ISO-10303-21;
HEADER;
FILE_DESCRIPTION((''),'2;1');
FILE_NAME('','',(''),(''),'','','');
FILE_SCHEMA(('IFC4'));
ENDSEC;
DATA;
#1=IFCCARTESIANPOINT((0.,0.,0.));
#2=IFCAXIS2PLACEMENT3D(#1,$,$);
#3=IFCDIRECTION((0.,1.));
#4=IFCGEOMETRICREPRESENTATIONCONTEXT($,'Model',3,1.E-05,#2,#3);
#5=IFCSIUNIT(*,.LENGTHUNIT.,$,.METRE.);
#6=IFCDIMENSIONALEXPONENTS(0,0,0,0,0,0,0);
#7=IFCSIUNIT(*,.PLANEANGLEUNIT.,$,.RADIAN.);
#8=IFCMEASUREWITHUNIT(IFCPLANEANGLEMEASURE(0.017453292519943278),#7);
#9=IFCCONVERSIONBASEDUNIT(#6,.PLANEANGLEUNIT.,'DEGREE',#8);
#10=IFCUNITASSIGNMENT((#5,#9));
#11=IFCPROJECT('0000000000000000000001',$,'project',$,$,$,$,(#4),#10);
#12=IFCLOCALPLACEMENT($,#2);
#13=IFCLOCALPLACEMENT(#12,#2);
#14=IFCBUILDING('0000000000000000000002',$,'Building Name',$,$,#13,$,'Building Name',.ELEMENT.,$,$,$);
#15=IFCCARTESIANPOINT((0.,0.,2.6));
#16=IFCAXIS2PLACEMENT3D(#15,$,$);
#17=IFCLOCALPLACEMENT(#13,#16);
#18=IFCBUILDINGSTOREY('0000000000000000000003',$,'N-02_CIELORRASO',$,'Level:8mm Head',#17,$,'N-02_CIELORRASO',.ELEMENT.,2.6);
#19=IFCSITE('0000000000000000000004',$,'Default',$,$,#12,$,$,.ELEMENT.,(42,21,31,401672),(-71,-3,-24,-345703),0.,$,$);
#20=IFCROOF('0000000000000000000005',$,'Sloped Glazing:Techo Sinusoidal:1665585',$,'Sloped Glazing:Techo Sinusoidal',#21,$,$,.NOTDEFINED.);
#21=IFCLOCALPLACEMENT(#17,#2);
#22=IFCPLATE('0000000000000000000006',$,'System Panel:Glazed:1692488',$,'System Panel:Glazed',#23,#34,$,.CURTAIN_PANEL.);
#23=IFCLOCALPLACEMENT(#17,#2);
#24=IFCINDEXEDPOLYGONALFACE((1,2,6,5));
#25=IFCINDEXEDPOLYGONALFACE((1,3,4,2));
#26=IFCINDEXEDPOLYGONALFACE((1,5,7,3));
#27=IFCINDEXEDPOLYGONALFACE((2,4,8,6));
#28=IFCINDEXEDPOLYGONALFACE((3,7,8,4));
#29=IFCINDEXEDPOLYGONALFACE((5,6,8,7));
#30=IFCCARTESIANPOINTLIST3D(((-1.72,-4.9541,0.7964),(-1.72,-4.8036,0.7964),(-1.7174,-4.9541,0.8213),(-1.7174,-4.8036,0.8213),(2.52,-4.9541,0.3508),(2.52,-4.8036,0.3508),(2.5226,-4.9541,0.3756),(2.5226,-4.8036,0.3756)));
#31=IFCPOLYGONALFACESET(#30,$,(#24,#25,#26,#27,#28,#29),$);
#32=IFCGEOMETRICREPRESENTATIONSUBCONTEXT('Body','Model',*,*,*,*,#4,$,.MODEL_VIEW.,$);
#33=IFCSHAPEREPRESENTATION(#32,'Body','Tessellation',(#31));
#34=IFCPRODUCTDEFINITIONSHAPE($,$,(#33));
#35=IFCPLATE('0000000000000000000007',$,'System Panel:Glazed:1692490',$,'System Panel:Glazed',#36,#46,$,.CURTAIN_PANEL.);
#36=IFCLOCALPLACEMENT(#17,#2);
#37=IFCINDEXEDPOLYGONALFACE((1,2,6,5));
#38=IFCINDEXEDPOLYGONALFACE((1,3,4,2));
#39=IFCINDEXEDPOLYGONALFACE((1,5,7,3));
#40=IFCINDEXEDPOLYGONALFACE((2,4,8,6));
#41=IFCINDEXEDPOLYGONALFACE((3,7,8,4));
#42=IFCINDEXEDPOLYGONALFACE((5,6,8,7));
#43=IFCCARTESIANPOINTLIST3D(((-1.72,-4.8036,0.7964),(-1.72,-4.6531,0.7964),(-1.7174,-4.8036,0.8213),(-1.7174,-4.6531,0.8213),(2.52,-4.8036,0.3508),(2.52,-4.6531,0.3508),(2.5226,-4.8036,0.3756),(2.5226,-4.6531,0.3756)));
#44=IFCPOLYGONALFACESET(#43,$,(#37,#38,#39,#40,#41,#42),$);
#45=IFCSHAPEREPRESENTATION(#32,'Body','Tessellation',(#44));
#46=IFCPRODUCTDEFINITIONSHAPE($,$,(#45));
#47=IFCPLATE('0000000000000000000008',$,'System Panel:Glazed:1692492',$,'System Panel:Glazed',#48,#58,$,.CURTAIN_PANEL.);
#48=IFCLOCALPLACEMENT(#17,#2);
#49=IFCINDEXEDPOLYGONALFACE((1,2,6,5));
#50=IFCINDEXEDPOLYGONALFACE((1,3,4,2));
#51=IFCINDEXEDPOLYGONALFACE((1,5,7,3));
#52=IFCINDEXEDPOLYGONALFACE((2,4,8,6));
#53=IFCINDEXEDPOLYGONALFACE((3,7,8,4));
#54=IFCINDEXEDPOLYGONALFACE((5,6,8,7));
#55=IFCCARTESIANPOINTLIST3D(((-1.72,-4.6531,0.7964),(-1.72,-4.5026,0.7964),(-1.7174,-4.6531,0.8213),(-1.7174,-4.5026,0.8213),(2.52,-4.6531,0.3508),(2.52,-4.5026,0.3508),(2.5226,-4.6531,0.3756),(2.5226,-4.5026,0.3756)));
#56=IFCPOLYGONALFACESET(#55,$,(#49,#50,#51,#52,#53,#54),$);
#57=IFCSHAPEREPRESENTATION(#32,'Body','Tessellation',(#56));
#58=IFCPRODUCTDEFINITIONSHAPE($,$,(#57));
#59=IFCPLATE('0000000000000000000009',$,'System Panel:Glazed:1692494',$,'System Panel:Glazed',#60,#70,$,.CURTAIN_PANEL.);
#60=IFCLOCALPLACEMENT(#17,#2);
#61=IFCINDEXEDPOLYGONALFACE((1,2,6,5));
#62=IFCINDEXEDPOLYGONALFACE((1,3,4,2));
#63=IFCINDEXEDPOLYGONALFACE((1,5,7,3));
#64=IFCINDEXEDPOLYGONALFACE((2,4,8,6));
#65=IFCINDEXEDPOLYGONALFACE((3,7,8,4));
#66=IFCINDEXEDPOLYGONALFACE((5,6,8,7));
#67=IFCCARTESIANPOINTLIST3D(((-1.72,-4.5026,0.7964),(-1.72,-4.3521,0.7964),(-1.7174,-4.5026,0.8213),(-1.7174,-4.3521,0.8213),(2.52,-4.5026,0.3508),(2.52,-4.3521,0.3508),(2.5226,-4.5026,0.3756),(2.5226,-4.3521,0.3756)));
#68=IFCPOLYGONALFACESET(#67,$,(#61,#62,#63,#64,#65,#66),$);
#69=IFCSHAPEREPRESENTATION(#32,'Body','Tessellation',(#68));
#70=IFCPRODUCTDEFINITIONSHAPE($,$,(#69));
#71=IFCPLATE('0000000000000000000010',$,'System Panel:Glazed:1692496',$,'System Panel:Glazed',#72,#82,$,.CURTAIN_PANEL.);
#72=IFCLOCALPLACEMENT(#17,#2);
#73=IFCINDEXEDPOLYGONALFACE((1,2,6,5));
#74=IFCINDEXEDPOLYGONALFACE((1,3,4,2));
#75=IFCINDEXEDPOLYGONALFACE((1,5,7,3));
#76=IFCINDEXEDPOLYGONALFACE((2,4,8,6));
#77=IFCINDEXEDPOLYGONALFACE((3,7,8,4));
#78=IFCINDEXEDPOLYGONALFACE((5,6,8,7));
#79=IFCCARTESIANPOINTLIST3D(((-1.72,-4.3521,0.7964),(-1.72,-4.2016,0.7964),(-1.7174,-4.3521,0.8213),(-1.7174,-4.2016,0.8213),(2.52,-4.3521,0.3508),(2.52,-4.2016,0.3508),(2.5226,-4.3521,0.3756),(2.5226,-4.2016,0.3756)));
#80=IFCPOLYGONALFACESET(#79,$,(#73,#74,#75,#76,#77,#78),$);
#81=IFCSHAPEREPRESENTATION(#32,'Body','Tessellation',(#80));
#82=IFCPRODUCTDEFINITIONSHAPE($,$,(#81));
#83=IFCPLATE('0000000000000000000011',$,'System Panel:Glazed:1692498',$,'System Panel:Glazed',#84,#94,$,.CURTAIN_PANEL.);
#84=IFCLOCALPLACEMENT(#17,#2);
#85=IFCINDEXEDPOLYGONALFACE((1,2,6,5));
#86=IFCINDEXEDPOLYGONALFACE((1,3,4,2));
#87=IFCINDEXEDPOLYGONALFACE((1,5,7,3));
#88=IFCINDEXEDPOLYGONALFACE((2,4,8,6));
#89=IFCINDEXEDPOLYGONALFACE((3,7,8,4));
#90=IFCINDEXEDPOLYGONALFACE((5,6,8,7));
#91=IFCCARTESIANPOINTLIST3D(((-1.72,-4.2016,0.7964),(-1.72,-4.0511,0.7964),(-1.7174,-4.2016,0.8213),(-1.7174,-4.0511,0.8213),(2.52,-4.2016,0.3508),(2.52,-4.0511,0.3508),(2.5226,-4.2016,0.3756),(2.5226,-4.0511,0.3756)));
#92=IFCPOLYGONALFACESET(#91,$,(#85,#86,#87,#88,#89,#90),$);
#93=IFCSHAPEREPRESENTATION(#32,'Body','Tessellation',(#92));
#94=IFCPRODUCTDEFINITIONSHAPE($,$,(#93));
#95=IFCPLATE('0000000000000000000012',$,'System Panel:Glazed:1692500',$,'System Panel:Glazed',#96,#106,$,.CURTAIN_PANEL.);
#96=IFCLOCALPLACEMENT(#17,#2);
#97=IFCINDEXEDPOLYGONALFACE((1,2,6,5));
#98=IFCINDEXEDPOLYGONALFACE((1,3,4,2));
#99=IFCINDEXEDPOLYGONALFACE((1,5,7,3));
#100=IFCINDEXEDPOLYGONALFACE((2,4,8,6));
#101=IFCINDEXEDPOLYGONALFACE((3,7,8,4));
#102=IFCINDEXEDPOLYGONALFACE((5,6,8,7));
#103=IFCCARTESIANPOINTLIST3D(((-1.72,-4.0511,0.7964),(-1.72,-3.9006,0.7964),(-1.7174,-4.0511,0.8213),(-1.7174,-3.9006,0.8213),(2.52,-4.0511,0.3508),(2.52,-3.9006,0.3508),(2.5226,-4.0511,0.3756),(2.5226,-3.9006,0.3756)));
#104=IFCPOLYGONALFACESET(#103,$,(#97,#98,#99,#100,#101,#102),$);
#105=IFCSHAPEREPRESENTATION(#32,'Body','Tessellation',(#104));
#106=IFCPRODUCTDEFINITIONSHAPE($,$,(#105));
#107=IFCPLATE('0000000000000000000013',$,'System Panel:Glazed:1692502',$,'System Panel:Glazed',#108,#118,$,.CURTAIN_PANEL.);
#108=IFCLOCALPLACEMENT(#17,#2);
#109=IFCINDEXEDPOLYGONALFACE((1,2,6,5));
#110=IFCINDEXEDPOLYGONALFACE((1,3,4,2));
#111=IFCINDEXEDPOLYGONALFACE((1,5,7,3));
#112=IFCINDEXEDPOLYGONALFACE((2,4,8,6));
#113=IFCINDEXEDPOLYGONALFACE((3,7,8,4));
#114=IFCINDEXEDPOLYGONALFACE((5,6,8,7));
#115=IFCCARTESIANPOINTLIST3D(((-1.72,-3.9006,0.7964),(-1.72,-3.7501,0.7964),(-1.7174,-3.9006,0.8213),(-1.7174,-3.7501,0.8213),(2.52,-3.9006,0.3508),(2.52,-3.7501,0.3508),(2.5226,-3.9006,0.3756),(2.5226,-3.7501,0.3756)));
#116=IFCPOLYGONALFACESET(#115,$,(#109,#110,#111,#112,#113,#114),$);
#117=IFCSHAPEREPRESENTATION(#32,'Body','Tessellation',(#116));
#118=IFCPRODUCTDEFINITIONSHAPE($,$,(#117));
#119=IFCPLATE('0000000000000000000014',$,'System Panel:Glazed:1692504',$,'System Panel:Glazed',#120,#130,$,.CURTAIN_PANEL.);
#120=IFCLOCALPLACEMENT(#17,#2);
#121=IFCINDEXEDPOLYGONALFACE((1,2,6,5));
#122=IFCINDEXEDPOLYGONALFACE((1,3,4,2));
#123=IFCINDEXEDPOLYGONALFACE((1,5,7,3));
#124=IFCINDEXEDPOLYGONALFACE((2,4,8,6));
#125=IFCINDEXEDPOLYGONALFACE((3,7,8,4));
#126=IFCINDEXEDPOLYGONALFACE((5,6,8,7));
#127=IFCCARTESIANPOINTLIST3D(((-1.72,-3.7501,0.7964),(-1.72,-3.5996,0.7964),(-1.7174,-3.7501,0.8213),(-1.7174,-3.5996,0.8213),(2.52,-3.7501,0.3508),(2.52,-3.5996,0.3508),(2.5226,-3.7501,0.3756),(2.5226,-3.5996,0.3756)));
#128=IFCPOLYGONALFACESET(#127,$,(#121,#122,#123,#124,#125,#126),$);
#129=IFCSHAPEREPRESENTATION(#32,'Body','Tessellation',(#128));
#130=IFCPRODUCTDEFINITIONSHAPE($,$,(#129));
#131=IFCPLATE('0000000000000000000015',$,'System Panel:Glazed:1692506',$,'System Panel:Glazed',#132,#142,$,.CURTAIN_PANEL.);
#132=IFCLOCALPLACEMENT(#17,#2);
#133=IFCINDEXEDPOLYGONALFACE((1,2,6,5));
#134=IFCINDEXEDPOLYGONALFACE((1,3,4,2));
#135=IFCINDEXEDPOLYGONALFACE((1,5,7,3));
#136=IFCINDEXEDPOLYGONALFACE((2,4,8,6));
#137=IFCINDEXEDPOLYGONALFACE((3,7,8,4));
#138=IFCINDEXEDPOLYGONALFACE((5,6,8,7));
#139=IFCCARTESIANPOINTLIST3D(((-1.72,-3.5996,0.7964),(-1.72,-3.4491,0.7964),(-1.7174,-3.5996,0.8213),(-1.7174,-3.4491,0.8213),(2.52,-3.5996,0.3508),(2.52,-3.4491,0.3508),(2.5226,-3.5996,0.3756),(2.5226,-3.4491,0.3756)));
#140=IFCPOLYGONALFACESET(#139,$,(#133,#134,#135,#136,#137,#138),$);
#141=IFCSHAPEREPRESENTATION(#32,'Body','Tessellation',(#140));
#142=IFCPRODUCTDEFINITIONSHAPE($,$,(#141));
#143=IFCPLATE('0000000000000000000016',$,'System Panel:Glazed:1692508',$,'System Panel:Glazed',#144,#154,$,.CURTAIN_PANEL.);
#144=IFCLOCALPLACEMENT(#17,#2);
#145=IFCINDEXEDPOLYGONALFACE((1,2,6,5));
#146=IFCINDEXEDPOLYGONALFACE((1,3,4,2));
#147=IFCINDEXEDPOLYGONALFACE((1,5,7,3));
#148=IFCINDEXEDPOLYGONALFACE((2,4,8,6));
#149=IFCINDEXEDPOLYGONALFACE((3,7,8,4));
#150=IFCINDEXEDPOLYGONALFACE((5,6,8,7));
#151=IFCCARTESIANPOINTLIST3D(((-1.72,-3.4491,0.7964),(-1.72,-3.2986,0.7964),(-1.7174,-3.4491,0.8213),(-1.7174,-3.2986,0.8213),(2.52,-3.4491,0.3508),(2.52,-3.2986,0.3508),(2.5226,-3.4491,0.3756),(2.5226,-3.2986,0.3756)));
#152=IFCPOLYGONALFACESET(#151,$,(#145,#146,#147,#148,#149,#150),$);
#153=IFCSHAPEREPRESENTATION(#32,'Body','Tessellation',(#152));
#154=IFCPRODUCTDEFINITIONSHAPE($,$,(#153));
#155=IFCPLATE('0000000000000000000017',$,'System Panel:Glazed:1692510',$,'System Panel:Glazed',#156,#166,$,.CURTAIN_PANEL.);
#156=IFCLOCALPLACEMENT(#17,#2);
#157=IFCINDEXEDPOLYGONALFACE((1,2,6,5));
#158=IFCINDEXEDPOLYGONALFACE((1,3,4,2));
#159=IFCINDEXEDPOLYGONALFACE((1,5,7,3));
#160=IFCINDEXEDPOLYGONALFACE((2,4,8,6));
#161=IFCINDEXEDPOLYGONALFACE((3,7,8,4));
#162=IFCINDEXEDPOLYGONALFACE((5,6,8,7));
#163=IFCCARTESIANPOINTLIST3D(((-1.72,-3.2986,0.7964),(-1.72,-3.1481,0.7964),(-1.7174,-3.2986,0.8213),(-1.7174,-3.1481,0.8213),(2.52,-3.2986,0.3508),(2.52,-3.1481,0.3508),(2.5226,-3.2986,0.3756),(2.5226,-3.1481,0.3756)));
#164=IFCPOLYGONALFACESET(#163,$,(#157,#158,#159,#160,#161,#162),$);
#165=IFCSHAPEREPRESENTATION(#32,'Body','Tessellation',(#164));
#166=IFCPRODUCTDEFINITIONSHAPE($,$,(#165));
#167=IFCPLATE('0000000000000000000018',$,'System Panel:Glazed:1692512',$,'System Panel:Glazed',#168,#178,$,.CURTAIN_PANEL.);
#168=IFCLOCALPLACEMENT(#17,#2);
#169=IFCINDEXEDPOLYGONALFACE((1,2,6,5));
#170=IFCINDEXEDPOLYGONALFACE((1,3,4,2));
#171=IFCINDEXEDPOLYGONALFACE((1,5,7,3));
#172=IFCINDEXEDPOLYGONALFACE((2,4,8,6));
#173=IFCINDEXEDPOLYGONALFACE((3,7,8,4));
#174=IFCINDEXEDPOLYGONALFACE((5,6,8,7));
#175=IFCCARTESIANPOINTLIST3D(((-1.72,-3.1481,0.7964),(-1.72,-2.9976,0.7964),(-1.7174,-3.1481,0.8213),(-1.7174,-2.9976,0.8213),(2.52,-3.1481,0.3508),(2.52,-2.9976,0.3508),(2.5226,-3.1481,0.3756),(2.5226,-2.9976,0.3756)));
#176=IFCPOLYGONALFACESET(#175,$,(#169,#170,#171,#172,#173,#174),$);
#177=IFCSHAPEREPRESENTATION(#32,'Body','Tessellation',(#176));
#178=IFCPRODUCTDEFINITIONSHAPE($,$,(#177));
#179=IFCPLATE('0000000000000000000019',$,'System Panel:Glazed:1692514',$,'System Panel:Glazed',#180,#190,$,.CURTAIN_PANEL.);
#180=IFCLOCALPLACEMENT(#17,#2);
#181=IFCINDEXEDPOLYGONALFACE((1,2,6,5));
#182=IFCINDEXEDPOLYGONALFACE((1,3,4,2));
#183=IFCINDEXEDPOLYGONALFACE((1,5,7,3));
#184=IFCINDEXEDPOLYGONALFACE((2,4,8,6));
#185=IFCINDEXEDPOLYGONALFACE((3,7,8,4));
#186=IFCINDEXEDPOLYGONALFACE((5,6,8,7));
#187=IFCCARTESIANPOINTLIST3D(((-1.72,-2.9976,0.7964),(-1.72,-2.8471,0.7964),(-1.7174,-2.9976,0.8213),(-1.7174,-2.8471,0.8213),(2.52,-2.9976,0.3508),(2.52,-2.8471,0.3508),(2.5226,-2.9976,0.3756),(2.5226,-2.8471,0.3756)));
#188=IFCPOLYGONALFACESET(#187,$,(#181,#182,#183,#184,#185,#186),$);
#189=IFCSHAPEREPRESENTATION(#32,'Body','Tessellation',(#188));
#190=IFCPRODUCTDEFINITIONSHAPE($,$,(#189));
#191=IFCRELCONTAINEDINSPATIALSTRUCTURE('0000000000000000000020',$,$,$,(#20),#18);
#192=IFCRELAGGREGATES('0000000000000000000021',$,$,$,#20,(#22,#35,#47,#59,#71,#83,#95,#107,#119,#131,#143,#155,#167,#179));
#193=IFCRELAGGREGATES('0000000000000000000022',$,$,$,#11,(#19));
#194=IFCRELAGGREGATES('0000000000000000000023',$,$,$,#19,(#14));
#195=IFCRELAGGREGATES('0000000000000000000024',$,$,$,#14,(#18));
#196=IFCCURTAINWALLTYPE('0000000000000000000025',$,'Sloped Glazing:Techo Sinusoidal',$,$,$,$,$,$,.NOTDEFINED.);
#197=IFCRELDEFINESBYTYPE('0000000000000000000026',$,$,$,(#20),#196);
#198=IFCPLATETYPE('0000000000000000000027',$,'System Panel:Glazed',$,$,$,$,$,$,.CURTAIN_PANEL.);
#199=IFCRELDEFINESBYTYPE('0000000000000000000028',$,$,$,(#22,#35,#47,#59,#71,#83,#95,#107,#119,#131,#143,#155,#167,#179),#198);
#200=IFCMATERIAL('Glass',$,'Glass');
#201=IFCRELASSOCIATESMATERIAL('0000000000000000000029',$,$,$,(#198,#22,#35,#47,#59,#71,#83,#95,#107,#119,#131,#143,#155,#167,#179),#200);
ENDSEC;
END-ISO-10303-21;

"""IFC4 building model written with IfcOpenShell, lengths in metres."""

from ifc_helpers import new_model, entity, si_unit, converted_unit, direction, frame, origin, place, context, subcontext, project, spatial, indexed_curve, outline, extrude, source, transform, mapped, material, type_object, type_shapes, element, aggregate, save


model = new_model("IFC4")

# Units and contexts
model_context = context("Model", 3, precision=1e-05, world=origin(), true_north=direction((0.0, 1.0)))
body_context = subcontext(model_context, "Body", "Model", "MODEL_VIEW")
ifc_project = project(units=[si_unit("LENGTHUNIT", "METRE"), converted_unit("PLANEANGLEUNIT", "DEGREE", entity("IfcPlaneAngleMeasure", 0.017453292519943278), si_unit("PLANEANGLEUNIT", "RADIAN"), dimensions=[0, 0, 0, 0, 0, 0, 0])], contexts=[model_context])

# Site, building, storey
site_placement = place(None, origin())
site = spatial("IfcSite", under=ifc_project, at=site_placement, Name="Default", CompositionType="ELEMENT", RefLatitude=(42, 21, 31, 401672), RefLongitude=(-71, -3, -24, -345703), RefElevation=0.0)
building_placement = place(site_placement, origin())
building = spatial("IfcBuilding", under=site, at=building_placement, Name="Building Name", LongName="Building Name", CompositionType="ELEMENT")
storey_placement = place(building_placement, frame((0.0, 0.0, 2.6)))
storey = spatial("IfcBuildingStorey", under=building, at=storey_placement, Name="N-02_CIELORRASO", ObjectType="Level:8mm Head", LongName="N-02_CIELORRASO", CompositionType="ELEMENT", Elevation=2.6)

# Roof, plates
curtain_wall_type = type_object("IfcCurtainWallType", Name="Sloped Glazing:Techo Sinusoidal", PredefinedType="NOTDEFINED")
roof_placement = place(storey_placement, frame((0.0, 0.0, -2.6)))
roof = element("IfcRoof", 1, at=roof_placement, inside=storey, type_object=curtain_wall_type, Name="Sloped Glazing:Techo Sinusoidal:1665585", ObjectType="Sloped Glazing:Techo Sinusoidal", PredefinedType="NOTDEFINED")
ifc_material_1 = material(Name="Glass", Category="Glass")
plate_type_1 = type_object("IfcPlateType", Name="System Panel:Glazed", PredefinedType="CURTAIN_PANEL", material=ifc_material_1)
shared_shape_1 = source(origin(), body_context, "Body", "SweptSolid", [
    extrude(outline(indexed_curve([(-0.0125, -0.0752), (0.0125, -0.0752), (0.0125, 0.0752), (-0.0125, 0.0752), (-0.0125, -0.0752)], self_intersect=False)), frame((0.0, 0.037, 0.0), z_axis=(0.0, 0.0, 1.0), x_axis=(0.0, 1.0, 0.0)), (0.0, 0.0, 1.0), 4.2634),
])
type_shapes(plate_type_1, [shared_shape_1])
plate_1_placement = place(roof_placement, frame((2.5252, -4.8789, 3.0), z_axis=(-0.994522, 0.0, 0.104528), x_axis=(0.0, 1.0, 0.0)))
plate_1 = element("IfcPlate", 2, at=plate_1_placement, type_object=plate_type_1, material=ifc_material_1, Name="System Panel:Glazed:1692488", ObjectType="System Panel:Glazed", PredefinedType="CURTAIN_PANEL", context=body_context, shape_type="MappedRepresentation", body=[
    mapped(shared_shape_1, transform((0.0, 0.0, 0.0), scale=1.0)),
])
plate_2_placement = place(roof_placement, frame((2.5252, -4.7284, 3.0), z_axis=(-0.994522, 0.0, 0.104528), x_axis=(0.0, 1.0, 0.0)))
plate_2 = element("IfcPlate", 3, at=plate_2_placement, type_object=plate_type_1, material=ifc_material_1, Name="System Panel:Glazed:1692490", ObjectType="System Panel:Glazed", PredefinedType="CURTAIN_PANEL", context=body_context, shape_type="MappedRepresentation", body=[
    mapped(shared_shape_1, transform((0.0, 0.0, 0.0), scale=1.0)),
])
plate_3_placement = place(roof_placement, frame((2.5252, -4.5779, 3.0), z_axis=(-0.994522, 0.0, 0.104528), x_axis=(0.0, 1.0, 0.0)))
plate_3 = element("IfcPlate", 4, at=plate_3_placement, type_object=plate_type_1, material=ifc_material_1, Name="System Panel:Glazed:1692492", ObjectType="System Panel:Glazed", PredefinedType="CURTAIN_PANEL", context=body_context, shape_type="MappedRepresentation", body=[
    mapped(shared_shape_1, transform((0.0, 0.0, 0.0), scale=1.0)),
])
plate_4_placement = place(roof_placement, frame((2.5252, -4.4274, 3.0), z_axis=(-0.994522, 0.0, 0.104528), x_axis=(0.0, 1.0, 0.0)))
plate_4 = element("IfcPlate", 5, at=plate_4_placement, type_object=plate_type_1, material=ifc_material_1, Name="System Panel:Glazed:1692494", ObjectType="System Panel:Glazed", PredefinedType="CURTAIN_PANEL", context=body_context, shape_type="MappedRepresentation", body=[
    mapped(shared_shape_1, transform((0.0, 0.0, 0.0), scale=1.0)),
])
plate_5_placement = place(roof_placement, frame((2.5252, -4.2769, 3.0), z_axis=(-0.994522, 0.0, 0.104528), x_axis=(0.0, 1.0, 0.0)))
plate_5 = element("IfcPlate", 6, at=plate_5_placement, type_object=plate_type_1, material=ifc_material_1, Name="System Panel:Glazed:1692496", ObjectType="System Panel:Glazed", PredefinedType="CURTAIN_PANEL", context=body_context, shape_type="MappedRepresentation", body=[
    mapped(shared_shape_1, transform((0.0, 0.0, 0.0), scale=1.0)),
])
plate_6_placement = place(roof_placement, frame((2.5252, -4.1264, 3.0), z_axis=(-0.994522, 0.0, 0.104528), x_axis=(0.0, 1.0, 0.0)))
plate_6 = element("IfcPlate", 7, at=plate_6_placement, type_object=plate_type_1, material=ifc_material_1, Name="System Panel:Glazed:1692498", ObjectType="System Panel:Glazed", PredefinedType="CURTAIN_PANEL", context=body_context, shape_type="MappedRepresentation", body=[
    mapped(shared_shape_1, transform((0.0, 0.0, 0.0), scale=1.0)),
])
plate_7_placement = place(roof_placement, frame((2.5252, -3.9759, 3.0), z_axis=(-0.994522, 0.0, 0.104528), x_axis=(0.0, 1.0, 0.0)))
plate_7 = element("IfcPlate", 8, at=plate_7_placement, type_object=plate_type_1, material=ifc_material_1, Name="System Panel:Glazed:1692500", ObjectType="System Panel:Glazed", PredefinedType="CURTAIN_PANEL", context=body_context, shape_type="MappedRepresentation", body=[
    mapped(shared_shape_1, transform((0.0, 0.0, 0.0), scale=1.0)),
])
plate_8_placement = place(roof_placement, frame((2.5252, -3.8254, 3.0), z_axis=(-0.994522, 0.0, 0.104528), x_axis=(0.0, 1.0, 0.0)))
plate_8 = element("IfcPlate", 9, at=plate_8_placement, type_object=plate_type_1, material=ifc_material_1, Name="System Panel:Glazed:1692502", ObjectType="System Panel:Glazed", PredefinedType="CURTAIN_PANEL", context=body_context, shape_type="MappedRepresentation", body=[
    mapped(shared_shape_1, transform((0.0, 0.0, 0.0), scale=1.0)),
])
plate_9_placement = place(roof_placement, frame((2.5252, -3.6749, 3.0), z_axis=(-0.994522, 0.0, 0.104528), x_axis=(0.0, 1.0, 0.0)))
plate_9 = element("IfcPlate", 10, at=plate_9_placement, type_object=plate_type_1, material=ifc_material_1, Name="System Panel:Glazed:1692504", ObjectType="System Panel:Glazed", PredefinedType="CURTAIN_PANEL", context=body_context, shape_type="MappedRepresentation", body=[
    mapped(shared_shape_1, transform((0.0, 0.0, 0.0), scale=1.0)),
])
plate_10_placement = place(roof_placement, frame((2.5252, -3.5244, 3.0), z_axis=(-0.994522, 0.0, 0.104528), x_axis=(0.0, 1.0, 0.0)))
plate_10 = element("IfcPlate", 11, at=plate_10_placement, type_object=plate_type_1, material=ifc_material_1, Name="System Panel:Glazed:1692506", ObjectType="System Panel:Glazed", PredefinedType="CURTAIN_PANEL", context=body_context, shape_type="MappedRepresentation", body=[
    mapped(shared_shape_1, transform((0.0, 0.0, 0.0), scale=1.0)),
])
plate_11_placement = place(roof_placement, frame((2.5252, -3.3739, 3.0), z_axis=(-0.994522, 0.0, 0.104528), x_axis=(0.0, 1.0, 0.0)))
plate_11 = element("IfcPlate", 12, at=plate_11_placement, type_object=plate_type_1, material=ifc_material_1, Name="System Panel:Glazed:1692508", ObjectType="System Panel:Glazed", PredefinedType="CURTAIN_PANEL", context=body_context, shape_type="MappedRepresentation", body=[
    mapped(shared_shape_1, transform((0.0, 0.0, 0.0), scale=1.0)),
])
plate_12_placement = place(roof_placement, frame((2.5252, -3.2234, 3.0), z_axis=(-0.994522, 0.0, 0.104528), x_axis=(0.0, 1.0, 0.0)))
plate_12 = element("IfcPlate", 13, at=plate_12_placement, type_object=plate_type_1, material=ifc_material_1, Name="System Panel:Glazed:1692510", ObjectType="System Panel:Glazed", PredefinedType="CURTAIN_PANEL", context=body_context, shape_type="MappedRepresentation", body=[
    mapped(shared_shape_1, transform((0.0, 0.0, 0.0), scale=1.0)),
])
plate_13_placement = place(roof_placement, frame((2.5252, -3.0729, 3.0), z_axis=(-0.994522, 0.0, 0.104528), x_axis=(0.0, 1.0, 0.0)))
plate_13 = element("IfcPlate", 14, at=plate_13_placement, type_object=plate_type_1, material=ifc_material_1, Name="System Panel:Glazed:1692512", ObjectType="System Panel:Glazed", PredefinedType="CURTAIN_PANEL", context=body_context, shape_type="MappedRepresentation", body=[
    mapped(shared_shape_1, transform((0.0, 0.0, 0.0), scale=1.0)),
])
plate_14_placement = place(roof_placement, frame((2.5252, -2.9224, 3.0), z_axis=(-0.994522, 0.0, 0.104528), x_axis=(0.0, 1.0, 0.0)))
plate_14 = element("IfcPlate", 15, at=plate_14_placement, type_object=plate_type_1, material=ifc_material_1, Name="System Panel:Glazed:1692514", ObjectType="System Panel:Glazed", PredefinedType="CURTAIN_PANEL", context=body_context, shape_type="MappedRepresentation", body=[
    mapped(shared_shape_1, transform((0.0, 0.0, 0.0), scale=1.0)),
])
aggregate(roof, [plate_1, plate_2, plate_3, plate_4, plate_5, plate_6, plate_7, plate_8, plate_9, plate_10, plate_11, plate_12, plate_13, plate_14])

save(model, "model.ifc")
